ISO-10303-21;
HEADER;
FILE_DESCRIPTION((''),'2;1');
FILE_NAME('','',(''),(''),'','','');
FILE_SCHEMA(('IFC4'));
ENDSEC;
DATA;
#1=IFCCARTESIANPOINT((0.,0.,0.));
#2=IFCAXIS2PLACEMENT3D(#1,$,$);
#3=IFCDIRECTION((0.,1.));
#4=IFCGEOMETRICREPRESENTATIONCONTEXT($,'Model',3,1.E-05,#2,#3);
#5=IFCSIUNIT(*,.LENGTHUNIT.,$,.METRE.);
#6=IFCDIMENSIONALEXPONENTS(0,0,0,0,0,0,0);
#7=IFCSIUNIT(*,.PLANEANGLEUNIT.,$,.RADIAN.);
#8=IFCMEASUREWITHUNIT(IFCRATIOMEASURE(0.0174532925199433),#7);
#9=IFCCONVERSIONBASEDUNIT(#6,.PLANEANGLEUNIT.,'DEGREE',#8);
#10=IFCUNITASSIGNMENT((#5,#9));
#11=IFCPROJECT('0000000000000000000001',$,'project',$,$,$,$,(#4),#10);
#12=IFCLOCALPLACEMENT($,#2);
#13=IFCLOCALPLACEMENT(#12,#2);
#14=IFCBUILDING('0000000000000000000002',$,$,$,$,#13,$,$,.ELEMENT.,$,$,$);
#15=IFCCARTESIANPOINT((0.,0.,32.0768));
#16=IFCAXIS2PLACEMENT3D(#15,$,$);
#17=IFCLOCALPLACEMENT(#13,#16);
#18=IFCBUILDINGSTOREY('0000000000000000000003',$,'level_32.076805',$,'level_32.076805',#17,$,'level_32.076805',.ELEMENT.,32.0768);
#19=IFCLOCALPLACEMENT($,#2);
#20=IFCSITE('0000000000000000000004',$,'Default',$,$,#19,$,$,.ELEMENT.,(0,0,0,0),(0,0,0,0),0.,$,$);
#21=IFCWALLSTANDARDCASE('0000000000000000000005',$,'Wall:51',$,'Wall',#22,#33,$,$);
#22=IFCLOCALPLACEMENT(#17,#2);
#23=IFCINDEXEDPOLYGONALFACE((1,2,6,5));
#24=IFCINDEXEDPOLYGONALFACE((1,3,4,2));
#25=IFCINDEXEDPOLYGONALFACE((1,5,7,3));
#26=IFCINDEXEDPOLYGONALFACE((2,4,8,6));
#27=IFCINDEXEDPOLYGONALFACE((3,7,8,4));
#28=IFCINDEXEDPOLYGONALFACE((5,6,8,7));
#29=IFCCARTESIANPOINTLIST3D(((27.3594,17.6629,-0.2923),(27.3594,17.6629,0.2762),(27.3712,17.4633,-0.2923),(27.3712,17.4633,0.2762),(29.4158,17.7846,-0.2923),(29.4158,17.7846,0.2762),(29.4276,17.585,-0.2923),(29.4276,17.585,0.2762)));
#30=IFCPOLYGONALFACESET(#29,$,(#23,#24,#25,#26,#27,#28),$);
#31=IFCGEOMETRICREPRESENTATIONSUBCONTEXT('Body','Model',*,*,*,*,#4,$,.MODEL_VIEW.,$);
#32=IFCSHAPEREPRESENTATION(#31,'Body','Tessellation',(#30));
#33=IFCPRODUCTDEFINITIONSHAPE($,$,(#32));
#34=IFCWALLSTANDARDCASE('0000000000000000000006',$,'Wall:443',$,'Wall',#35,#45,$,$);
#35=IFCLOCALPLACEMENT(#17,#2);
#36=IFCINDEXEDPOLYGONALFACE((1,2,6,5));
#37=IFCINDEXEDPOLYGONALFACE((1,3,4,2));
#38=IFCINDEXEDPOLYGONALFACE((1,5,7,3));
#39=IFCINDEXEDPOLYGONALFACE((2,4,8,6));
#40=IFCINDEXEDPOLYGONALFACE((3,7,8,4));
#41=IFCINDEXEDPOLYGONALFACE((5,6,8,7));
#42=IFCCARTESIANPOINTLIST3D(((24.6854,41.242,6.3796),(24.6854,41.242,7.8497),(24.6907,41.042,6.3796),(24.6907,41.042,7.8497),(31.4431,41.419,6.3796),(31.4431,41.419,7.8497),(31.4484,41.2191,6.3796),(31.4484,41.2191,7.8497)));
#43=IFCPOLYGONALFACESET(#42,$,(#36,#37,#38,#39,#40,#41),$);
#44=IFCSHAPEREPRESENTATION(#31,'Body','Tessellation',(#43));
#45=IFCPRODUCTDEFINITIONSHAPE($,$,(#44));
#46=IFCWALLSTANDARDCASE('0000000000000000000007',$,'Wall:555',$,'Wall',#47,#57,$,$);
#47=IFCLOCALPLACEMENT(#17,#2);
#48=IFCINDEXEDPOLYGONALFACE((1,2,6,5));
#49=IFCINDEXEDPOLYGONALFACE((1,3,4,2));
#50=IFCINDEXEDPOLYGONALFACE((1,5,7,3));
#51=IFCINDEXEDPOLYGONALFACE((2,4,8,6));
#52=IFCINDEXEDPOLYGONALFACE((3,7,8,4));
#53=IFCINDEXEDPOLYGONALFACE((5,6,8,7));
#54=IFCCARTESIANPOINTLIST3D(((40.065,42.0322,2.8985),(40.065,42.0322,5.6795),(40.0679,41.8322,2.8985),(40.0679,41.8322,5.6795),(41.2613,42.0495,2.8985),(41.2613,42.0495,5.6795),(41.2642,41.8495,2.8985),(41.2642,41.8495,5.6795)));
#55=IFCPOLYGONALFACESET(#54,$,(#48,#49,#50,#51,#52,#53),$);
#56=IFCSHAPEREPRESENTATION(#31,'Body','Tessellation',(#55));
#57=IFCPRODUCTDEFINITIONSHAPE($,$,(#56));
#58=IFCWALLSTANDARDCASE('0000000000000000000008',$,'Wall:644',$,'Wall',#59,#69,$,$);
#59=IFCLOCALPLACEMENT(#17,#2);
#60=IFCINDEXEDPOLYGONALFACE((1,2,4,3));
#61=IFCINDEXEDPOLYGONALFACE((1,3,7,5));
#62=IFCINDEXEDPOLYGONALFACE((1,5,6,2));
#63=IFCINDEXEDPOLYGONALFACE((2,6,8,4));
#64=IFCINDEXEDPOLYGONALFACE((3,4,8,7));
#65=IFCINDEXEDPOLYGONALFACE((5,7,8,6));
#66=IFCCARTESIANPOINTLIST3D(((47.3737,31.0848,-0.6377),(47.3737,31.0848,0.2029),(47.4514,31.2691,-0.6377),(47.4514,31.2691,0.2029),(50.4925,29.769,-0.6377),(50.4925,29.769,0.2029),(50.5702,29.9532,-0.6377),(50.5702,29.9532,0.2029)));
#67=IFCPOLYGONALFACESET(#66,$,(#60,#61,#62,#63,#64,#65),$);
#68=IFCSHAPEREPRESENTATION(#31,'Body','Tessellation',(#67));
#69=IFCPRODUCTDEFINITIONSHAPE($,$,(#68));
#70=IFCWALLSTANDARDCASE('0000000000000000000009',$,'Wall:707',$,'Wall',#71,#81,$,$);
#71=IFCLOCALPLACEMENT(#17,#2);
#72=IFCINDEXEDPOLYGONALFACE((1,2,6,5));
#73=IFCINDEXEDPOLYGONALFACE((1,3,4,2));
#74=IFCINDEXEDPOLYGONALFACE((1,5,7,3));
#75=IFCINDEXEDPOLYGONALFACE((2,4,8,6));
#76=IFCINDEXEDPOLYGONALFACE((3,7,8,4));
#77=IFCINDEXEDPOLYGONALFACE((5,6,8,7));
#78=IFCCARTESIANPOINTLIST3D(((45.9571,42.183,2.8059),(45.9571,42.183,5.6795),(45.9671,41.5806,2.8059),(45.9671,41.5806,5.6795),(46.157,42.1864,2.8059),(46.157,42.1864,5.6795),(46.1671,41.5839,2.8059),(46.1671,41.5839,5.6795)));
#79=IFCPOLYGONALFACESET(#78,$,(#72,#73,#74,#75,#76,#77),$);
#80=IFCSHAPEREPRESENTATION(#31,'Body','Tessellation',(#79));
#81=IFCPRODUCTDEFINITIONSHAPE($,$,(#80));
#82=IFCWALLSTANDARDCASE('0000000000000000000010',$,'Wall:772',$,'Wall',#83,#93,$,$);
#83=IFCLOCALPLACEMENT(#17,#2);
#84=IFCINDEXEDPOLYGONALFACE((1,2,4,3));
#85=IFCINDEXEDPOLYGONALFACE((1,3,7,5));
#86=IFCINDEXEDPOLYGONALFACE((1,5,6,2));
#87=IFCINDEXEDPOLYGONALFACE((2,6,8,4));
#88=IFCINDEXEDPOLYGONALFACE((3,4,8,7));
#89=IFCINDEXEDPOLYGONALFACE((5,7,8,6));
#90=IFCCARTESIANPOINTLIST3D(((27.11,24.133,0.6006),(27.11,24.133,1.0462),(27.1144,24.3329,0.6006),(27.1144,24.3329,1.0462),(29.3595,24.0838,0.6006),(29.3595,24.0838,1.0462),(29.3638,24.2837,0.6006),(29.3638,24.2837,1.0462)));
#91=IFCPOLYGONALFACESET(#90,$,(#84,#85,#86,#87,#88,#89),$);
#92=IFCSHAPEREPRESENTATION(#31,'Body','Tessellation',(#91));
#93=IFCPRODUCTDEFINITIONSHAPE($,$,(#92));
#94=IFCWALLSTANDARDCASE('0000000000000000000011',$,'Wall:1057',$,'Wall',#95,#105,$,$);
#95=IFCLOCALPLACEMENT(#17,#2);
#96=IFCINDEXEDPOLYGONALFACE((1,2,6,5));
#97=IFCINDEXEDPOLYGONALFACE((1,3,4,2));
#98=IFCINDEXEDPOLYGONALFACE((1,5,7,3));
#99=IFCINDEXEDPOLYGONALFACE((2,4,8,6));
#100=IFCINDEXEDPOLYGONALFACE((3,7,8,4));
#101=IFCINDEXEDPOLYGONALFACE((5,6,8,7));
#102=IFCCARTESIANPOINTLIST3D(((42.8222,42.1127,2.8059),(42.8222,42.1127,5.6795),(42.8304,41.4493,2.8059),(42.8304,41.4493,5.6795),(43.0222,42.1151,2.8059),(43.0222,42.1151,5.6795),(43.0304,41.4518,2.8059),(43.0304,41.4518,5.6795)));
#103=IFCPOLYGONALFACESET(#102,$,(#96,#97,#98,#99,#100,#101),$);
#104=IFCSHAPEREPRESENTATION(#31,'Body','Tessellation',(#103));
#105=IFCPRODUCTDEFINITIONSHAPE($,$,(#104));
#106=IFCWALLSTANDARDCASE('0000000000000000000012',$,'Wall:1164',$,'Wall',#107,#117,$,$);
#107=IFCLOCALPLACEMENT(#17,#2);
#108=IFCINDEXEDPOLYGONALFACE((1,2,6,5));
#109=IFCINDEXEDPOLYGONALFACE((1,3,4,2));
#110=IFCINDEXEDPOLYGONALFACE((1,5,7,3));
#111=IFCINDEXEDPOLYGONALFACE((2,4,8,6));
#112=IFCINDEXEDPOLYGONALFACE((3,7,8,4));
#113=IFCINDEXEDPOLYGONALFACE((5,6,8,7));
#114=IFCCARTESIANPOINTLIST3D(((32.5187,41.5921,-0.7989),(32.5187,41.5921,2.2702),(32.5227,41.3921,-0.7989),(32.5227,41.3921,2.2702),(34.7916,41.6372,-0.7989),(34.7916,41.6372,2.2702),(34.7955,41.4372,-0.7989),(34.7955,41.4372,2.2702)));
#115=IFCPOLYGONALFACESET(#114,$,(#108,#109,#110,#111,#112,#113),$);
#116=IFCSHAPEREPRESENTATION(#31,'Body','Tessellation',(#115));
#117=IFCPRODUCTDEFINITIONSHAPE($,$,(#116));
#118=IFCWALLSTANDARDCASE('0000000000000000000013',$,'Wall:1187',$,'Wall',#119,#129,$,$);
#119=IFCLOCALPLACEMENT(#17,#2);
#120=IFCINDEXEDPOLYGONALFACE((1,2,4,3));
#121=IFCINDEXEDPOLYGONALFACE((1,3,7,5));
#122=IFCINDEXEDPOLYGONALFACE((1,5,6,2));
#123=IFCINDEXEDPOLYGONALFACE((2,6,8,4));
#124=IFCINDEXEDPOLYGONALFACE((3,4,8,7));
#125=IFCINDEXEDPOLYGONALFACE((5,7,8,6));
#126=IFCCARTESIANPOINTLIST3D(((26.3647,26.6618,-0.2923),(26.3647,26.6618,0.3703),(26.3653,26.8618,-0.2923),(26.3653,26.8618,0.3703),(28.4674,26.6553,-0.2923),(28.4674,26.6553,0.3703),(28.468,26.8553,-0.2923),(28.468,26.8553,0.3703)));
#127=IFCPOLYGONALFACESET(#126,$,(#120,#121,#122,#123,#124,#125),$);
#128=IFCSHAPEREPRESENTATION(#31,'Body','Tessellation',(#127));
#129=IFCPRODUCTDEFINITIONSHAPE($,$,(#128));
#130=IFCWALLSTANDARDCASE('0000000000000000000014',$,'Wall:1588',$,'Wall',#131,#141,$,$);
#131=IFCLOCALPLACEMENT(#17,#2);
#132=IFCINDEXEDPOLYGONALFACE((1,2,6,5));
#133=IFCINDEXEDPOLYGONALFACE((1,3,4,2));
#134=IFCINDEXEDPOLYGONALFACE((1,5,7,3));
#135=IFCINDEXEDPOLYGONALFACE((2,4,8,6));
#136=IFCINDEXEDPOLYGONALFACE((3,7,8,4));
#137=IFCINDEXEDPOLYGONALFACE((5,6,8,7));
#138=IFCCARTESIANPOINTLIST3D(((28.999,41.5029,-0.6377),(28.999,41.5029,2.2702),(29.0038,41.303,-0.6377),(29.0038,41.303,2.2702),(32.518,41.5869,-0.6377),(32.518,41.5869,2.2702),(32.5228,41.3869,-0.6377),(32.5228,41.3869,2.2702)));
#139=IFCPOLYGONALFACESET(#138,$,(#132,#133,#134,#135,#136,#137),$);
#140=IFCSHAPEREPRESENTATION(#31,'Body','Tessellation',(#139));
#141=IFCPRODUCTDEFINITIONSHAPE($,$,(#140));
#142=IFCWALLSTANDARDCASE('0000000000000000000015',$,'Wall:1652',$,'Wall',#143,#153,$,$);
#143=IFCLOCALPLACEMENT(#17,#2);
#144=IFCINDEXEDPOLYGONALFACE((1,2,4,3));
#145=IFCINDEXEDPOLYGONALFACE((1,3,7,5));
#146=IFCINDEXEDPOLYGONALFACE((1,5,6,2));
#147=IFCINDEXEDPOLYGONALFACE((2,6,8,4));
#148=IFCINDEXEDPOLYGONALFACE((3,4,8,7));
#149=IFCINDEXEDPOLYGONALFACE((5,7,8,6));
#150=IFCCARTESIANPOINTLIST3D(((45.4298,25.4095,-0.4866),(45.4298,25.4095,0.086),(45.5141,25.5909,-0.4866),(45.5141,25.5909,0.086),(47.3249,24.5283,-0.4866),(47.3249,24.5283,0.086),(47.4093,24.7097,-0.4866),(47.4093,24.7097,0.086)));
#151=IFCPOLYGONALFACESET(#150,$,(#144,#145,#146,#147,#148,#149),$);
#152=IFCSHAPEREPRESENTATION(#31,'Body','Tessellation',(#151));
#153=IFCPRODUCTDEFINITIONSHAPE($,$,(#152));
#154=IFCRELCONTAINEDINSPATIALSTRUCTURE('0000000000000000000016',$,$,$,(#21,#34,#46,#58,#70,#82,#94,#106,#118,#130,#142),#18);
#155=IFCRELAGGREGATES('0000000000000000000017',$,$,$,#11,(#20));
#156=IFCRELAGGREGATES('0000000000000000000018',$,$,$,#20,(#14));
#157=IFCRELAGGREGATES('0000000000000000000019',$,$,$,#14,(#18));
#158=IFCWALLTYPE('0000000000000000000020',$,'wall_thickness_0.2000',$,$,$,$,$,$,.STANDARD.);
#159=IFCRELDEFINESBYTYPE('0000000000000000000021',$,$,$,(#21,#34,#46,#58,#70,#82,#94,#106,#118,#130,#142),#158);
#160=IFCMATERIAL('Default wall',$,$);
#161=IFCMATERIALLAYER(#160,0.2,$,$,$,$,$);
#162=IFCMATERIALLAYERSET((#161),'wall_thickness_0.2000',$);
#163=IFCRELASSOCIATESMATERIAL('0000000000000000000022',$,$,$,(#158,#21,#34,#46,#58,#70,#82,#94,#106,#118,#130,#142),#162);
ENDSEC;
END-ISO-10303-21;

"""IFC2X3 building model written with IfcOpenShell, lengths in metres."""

from ifc_helpers import new_model, entity, si_unit, converted_unit, direction, frame, origin, place, context, subcontext, project, spatial, polyline, outline, extrude, material, layer, layer_set, layer_usage, type_object, element, save


model = new_model("IFC2X3")

# Units and contexts
model_context = context("Model", 3, precision=1e-05, world=origin(), true_north=direction((0.0, 1.0)))
body_context = subcontext(model_context, "Body", "Model", "MODEL_VIEW")
ifc_project = project(units=[si_unit("LENGTHUNIT", "METRE"), converted_unit("PLANEANGLEUNIT", "DEGREE", entity("IfcRatioMeasure", 0.0174532925199433), si_unit("PLANEANGLEUNIT", "RADIAN"), dimensions=[0, 0, 0, 0, 0, 0, 0])], contexts=[model_context])

# Site, building, storey
site_placement = place(None, origin())
site = spatial("IfcSite", under=ifc_project, at=site_placement, Name="Default", CompositionType="ELEMENT", RefLatitude=(0, 0, 0, 0), RefLongitude=(0, 0, 0, 0), RefElevation=0.0)
placement_1 = place(None, origin())
building_placement = place(placement_1, origin())
building = spatial("IfcBuilding", under=site, at=building_placement, CompositionType="ELEMENT")
storey_placement = place(building_placement, frame((0.0, 0.0, 32.0768)))
storey = spatial("IfcBuildingStorey", under=building, at=storey_placement, Name="level_32.076805", ObjectType="level_32.076805", LongName="level_32.076805", CompositionType="ELEMENT", Elevation=32.0768)

# Walls
ifc_material_1 = material(Name="Default wall")
ifc_layer = layer(ifc_material_1, 0.2)
ifc_layer_set = layer_set([ifc_layer], Name="wall_thickness_0.2000")
ifc_layer_usage = layer_usage(ifc_layer_set, "AXIS2", "POSITIVE", -0.1)
wall_type = type_object("IfcWallType", Name="wall_thickness_0.2000", PredefinedType="STANDARD", material=ifc_layer_set)
placement_2 = place(building_placement, frame((0.0, 0.0, 31.7845)))
wall_1_placement = place(placement_2, frame((27.3653, 17.5631, 0.0), z_axis=(0.0, 0.0, 1.0), x_axis=(0.998253, 0.05908, 0.0)))
element("IfcWallStandardCase", 1, at=wall_1_placement, inside=storey, type_object=wall_type, material=ifc_layer_usage, Name="Wall:51", ObjectType="Wall", context=body_context, shape_type="SweptSolid", body=[
    extrude(outline(polyline([(2.06, -0.1), (2.06, 0.1), (0.0, 0.1), (0.0, -0.1), (2.06, -0.1)])), origin(), (0.0, 0.0, 1.0), 0.5684),
])
placement_3 = place(building_placement, frame((0.0, 0.0, 38.4564)))
wall_2_placement = place(placement_3, frame((24.6881, 41.142, 0.0), z_axis=(0.0, 0.0, 1.0), x_axis=(0.999657, 0.026191, 0.0)))
element("IfcWallStandardCase", 2, at=wall_2_placement, inside=storey, type_object=wall_type, material=ifc_layer_usage, Name="Wall:443", ObjectType="Wall", context=body_context, shape_type="SweptSolid", body=[
    extrude(outline(polyline([(6.76, -0.1), (6.76, 0.1), (0.0, 0.1), (0.0, -0.1), (6.76, -0.1)])), origin(), (0.0, 0.0, 1.0), 1.4701),
])
placement_4 = place(building_placement, frame((0.0, 0.0, 34.9753)))
wall_3_placement = place(placement_4, frame((41.2627, 41.9495, 0.0), z_axis=(0.0, 0.0, 1.0), x_axis=(-0.999895, -0.014466, 0.0)))
element("IfcWallStandardCase", 3, at=wall_3_placement, inside=storey, type_object=wall_type, material=ifc_layer_usage, Name="Wall:555", ObjectType="Wall", context=body_context, shape_type="SweptSolid", body=[
    extrude(outline(polyline([(1.1964, -0.1), (1.1964, 0.1), (0.0, 0.1), (0.0, -0.1), (1.1964, -0.1)])), origin(), (0.0, 0.0, 1.0), 2.7811),
])
placement_5 = place(building_placement, frame((0.0, 0.0, 31.4391)))
wall_4_placement = place(placement_5, frame((47.4126, 31.177, 0.0), z_axis=(0.0, 0.0, 1.0), x_axis=(0.921349, -0.388737, 0.0)))
element("IfcWallStandardCase", 4, at=wall_4_placement, inside=storey, type_object=wall_type, material=ifc_layer_usage, Name="Wall:644", ObjectType="Wall", context=body_context, shape_type="SweptSolid", body=[
    extrude(outline(polyline([(3.385, -0.1), (3.385, 0.1), (0.0, 0.1), (0.0, -0.1), (3.385, -0.1)])), origin(), (0.0, 0.0, 1.0), 0.8406),
])
placement_6 = place(building_placement, frame((0.0, 0.0, 34.8827)))
wall_5_placement = place(placement_6, frame((46.0571, 42.1847, 0.0), z_axis=(0.0, 0.0, 1.0), x_axis=(0.016702, -0.999861, 0.0)))
element("IfcWallStandardCase", 5, at=wall_5_placement, inside=storey, type_object=wall_type, material=ifc_layer_usage, Name="Wall:707", ObjectType="Wall", context=body_context, shape_type="SweptSolid", body=[
    extrude(outline(polyline([(0.6025, -0.1), (0.6025, 0.1), (0.0, 0.1), (0.0, -0.1), (0.6025, -0.1)])), origin(), (0.0, 0.0, 1.0), 2.8737),
])
placement_7 = place(building_placement, frame((0.0, 0.0, 32.6774)))
wall_6_placement = place(placement_7, frame((27.1122, 24.2329, 0.0), z_axis=(0.0, 0.0, 1.0), x_axis=(0.999761, -0.021857, 0.0)))
element("IfcWallStandardCase", 6, at=wall_6_placement, inside=storey, type_object=wall_type, material=ifc_layer_usage, Name="Wall:772", ObjectType="Wall", context=body_context, shape_type="SweptSolid", body=[
    extrude(outline(polyline([(2.25, -0.1), (2.25, 0.1), (0.0, 0.1), (0.0, -0.1), (2.25, -0.1)])), origin(), (0.0, 0.0, 1.0), 0.4456),
])
placement_8 = place(building_placement, frame((0.0, 0.0, 34.8827)))
wall_7_placement = place(placement_8, frame((42.9222, 42.1139, 0.0), z_axis=(0.0, 0.0, 1.0), x_axis=(0.012364, -0.999924, 0.0)))
element("IfcWallStandardCase", 7, at=wall_7_placement, inside=storey, type_object=wall_type, material=ifc_layer_usage, Name="Wall:1057", ObjectType="Wall", context=body_context, shape_type="SweptSolid", body=[
    extrude(outline(polyline([(0.6634, -0.1), (0.6634, 0.1), (0.0, 0.1), (0.0, -0.1), (0.6634, -0.1)])), origin(), (0.0, 0.0, 1.0), 2.8737),
])
placement_9 = place(building_placement, frame((0.0, 0.0, 31.2779)))
wall_8_placement = place(placement_9, frame((32.5207, 41.4921, 0.0), z_axis=(0.0, 0.0, 1.0), x_axis=(0.999803, 0.019843, 0.0)))
element("IfcWallStandardCase", 8, at=wall_8_placement, inside=storey, type_object=wall_type, material=ifc_layer_usage, Name="Wall:1164", ObjectType="Wall", context=body_context, shape_type="SweptSolid", body=[
    extrude(outline(polyline([(2.2733, -0.1), (2.2733, 0.1), (0.0, 0.1), (0.0, -0.1), (2.2733, -0.1)])), origin(), (0.0, 0.0, 1.0), 3.069),
])
placement_10 = place(building_placement, frame((0.0, 0.0, 31.7845)))
wall_9_placement = place(placement_10, frame((26.365, 26.7618, 0.0), z_axis=(0.0, 0.0, 1.0), x_axis=(0.999995, -0.003101, 0.0)))
element("IfcWallStandardCase", 9, at=wall_9_placement, inside=storey, type_object=wall_type, material=ifc_layer_usage, Name="Wall:1187", ObjectType="Wall", context=body_context, shape_type="SweptSolid", body=[
    extrude(outline(polyline([(2.1027, -0.1), (2.1027, 0.1), (0.0, 0.1), (0.0, -0.1), (2.1027, -0.1)])), origin(), (0.0, 0.0, 1.0), 0.6626),
])
placement_11 = place(building_placement, frame((0.0, 0.0, 31.4391)))
wall_10_placement = place(placement_11, frame((29.0014, 41.4029, 0.0), z_axis=(0.0, 0.0, 1.0), x_axis=(0.999716, 0.023851, 0.0)))
element("IfcWallStandardCase", 10, at=wall_10_placement, inside=storey, type_object=wall_type, material=ifc_layer_usage, Name="Wall:1588", ObjectType="Wall", context=body_context, shape_type="SweptSolid", body=[
    extrude(outline(polyline([(3.52, -0.1), (3.52, 0.1), (0.0, 0.1), (0.0, -0.1), (3.52, -0.1)])), origin(), (0.0, 0.0, 1.0), 2.9079),
])
placement_12 = place(building_placement, frame((0.0, 0.0, 31.5902)))
wall_11_placement = place(placement_12, frame((45.4719, 25.5002, 0.0), z_axis=(0.0, 0.0, 1.0), x_axis=(0.906775, -0.421616, 0.0)))
element("IfcWallStandardCase", 11, at=wall_11_placement, inside=storey, type_object=wall_type, material=ifc_layer_usage, Name="Wall:1652", ObjectType="Wall", context=body_context, shape_type="SweptSolid", body=[
    extrude(outline(polyline([(2.09, -0.1), (2.09, 0.1), (0.0, 0.1), (0.0, -0.1), (2.09, -0.1)])), origin(), (0.0, 0.0, 1.0), 0.5726),
])

save(model, "model.ifc")
